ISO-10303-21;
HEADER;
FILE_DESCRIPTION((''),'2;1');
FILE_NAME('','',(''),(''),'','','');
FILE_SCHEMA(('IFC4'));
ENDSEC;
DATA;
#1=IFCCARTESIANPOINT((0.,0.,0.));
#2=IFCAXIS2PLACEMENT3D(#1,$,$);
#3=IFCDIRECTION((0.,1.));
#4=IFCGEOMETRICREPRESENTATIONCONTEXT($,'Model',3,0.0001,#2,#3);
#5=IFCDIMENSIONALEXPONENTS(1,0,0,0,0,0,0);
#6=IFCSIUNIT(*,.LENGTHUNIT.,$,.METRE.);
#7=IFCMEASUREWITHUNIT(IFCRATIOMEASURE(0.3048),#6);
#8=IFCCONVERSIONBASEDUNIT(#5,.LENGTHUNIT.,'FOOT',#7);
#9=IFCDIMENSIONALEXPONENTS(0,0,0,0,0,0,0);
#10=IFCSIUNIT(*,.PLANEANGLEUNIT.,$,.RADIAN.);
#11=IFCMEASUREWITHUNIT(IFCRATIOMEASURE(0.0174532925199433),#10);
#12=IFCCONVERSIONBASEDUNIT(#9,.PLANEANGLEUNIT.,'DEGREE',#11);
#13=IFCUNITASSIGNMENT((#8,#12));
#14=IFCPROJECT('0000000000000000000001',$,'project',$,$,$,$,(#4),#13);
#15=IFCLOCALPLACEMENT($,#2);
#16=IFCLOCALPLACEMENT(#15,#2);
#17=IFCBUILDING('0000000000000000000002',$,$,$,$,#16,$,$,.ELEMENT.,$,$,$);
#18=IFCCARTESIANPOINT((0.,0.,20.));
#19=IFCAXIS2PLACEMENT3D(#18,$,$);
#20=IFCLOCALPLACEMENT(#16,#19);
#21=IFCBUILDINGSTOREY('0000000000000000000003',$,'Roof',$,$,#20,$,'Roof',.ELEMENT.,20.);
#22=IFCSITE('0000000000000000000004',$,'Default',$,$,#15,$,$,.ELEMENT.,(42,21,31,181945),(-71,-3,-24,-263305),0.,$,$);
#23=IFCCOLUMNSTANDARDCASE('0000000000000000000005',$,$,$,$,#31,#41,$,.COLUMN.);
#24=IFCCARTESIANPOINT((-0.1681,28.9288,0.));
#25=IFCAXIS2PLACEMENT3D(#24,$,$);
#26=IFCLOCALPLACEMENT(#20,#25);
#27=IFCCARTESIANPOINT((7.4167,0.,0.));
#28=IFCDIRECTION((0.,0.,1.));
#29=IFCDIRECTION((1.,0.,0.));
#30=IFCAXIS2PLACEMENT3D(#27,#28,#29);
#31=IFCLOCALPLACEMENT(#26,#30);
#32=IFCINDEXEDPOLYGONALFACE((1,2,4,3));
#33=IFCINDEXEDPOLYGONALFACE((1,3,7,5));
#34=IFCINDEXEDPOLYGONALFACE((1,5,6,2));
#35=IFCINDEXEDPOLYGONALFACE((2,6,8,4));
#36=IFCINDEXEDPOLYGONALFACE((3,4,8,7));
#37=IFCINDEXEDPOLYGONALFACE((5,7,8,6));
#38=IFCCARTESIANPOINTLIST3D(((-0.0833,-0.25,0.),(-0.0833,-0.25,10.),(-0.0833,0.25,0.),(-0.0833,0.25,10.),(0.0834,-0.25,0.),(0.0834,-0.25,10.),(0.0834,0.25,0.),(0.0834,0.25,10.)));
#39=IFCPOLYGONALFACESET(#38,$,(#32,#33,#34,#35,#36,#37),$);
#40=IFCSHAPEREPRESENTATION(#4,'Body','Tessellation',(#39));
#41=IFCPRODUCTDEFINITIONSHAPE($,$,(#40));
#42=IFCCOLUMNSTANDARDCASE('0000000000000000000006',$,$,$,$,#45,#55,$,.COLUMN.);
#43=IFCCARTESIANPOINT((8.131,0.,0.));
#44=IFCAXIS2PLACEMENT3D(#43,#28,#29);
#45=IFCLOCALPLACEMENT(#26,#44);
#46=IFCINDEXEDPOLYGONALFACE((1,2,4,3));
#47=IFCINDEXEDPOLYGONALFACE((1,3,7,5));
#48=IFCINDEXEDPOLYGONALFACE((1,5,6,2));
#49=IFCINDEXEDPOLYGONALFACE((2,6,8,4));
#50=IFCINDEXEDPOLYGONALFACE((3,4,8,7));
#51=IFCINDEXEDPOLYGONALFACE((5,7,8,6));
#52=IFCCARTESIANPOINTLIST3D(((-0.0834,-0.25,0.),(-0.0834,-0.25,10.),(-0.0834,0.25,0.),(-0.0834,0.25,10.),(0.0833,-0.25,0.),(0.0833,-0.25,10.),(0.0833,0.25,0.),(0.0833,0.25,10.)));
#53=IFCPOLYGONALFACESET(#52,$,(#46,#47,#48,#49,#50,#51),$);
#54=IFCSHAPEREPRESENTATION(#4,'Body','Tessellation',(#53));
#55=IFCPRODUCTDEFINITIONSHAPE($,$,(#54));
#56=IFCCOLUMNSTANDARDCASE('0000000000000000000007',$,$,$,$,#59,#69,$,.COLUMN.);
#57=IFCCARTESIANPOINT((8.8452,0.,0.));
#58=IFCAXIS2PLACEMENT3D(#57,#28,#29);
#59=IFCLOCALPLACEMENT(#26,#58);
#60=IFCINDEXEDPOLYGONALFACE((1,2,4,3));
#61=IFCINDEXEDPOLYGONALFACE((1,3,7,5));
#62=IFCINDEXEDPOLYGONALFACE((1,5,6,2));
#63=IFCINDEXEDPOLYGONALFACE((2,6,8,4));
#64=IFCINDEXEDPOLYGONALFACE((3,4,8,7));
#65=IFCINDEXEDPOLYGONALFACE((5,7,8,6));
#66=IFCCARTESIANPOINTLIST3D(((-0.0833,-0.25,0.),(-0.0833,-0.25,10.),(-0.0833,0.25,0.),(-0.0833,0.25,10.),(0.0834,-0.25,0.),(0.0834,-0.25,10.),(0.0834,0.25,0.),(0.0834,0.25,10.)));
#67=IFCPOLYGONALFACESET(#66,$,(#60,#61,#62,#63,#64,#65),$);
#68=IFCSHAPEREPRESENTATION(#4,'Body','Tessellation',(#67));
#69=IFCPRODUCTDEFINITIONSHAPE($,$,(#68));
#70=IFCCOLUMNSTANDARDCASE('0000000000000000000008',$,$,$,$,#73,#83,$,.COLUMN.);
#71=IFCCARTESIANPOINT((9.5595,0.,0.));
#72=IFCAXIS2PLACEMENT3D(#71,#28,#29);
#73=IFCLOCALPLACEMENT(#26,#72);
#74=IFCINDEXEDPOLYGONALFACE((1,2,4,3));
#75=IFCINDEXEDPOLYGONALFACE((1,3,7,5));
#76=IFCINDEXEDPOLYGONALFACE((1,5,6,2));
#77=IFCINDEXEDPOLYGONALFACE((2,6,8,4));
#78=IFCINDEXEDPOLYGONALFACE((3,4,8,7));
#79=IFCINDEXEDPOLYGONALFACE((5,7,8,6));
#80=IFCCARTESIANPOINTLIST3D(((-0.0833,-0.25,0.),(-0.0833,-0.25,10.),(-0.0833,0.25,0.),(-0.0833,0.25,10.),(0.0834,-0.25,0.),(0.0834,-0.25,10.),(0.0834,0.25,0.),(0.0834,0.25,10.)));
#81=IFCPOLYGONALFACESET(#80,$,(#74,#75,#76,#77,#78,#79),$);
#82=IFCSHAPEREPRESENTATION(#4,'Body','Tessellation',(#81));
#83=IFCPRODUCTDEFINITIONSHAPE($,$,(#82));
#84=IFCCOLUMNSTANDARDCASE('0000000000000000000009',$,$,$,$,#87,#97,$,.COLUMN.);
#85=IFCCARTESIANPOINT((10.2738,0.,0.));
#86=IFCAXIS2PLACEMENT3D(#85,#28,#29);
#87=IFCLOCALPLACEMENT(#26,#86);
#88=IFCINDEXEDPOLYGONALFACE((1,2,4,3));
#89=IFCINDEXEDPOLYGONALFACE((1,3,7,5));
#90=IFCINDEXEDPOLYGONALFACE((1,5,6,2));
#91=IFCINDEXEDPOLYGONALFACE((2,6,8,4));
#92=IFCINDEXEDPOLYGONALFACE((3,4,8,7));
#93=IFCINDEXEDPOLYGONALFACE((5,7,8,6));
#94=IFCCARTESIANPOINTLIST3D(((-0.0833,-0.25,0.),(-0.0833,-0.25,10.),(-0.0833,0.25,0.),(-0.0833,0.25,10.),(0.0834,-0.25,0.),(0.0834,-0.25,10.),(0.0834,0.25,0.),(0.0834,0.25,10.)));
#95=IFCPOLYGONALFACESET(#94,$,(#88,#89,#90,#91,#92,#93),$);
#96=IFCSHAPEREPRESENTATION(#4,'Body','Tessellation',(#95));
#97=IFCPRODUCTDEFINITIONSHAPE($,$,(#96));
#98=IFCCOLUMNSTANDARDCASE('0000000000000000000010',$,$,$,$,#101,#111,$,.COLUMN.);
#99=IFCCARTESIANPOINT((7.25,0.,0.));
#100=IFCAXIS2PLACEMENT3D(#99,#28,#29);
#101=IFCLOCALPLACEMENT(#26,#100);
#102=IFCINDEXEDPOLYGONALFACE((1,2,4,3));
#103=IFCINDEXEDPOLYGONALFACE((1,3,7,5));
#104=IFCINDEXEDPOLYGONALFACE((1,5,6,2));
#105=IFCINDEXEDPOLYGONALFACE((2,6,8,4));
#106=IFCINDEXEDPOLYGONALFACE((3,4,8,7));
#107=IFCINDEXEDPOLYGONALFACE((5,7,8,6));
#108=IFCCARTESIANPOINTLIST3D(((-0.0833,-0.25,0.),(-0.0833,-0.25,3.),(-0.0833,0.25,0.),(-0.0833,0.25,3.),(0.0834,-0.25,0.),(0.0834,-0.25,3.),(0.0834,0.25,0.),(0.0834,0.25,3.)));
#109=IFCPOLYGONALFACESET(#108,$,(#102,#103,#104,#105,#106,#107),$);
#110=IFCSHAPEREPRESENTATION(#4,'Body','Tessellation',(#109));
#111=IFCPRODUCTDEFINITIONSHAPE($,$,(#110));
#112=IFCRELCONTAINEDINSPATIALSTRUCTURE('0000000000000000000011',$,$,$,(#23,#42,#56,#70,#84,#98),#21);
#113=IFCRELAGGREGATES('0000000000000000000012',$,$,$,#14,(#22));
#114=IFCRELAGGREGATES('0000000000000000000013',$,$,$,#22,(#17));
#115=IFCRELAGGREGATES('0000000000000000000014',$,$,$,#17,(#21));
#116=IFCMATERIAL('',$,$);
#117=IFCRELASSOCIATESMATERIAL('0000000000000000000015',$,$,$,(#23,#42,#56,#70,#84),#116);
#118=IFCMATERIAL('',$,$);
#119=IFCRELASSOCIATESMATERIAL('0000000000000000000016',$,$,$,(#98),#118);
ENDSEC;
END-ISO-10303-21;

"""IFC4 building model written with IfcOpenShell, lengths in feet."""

from ifc_helpers import new_model, entity, si_unit, converted_unit, direction, frame, origin, place, context, project, spatial, rectangle, extrude, material, element, save


model = new_model("IFC4")

# Units and contexts
model_context = context("Model", 3, precision=0.0001, world=origin(), true_north=direction((0.0, 1.0)))
ifc_project = project(units=[converted_unit("LENGTHUNIT", "FOOT", entity("IfcRatioMeasure", 0.3048), si_unit("LENGTHUNIT", "METRE"), dimensions=[1, 0, 0, 0, 0, 0, 0]), converted_unit("PLANEANGLEUNIT", "DEGREE", entity("IfcRatioMeasure", 0.0174532925199433), si_unit("PLANEANGLEUNIT", "RADIAN"), dimensions=[0, 0, 0, 0, 0, 0, 0])], contexts=[model_context])

# Site, building, storey
site_placement = place(None, origin())
site = spatial("IfcSite", under=ifc_project, at=site_placement, Name="Default", CompositionType="ELEMENT", RefLatitude=(42, 21, 31, 181945), RefLongitude=(-71, -3, -24, -263305), RefElevation=0.0)
building_placement = place(site_placement, origin())
building = spatial("IfcBuilding", under=site, at=building_placement, CompositionType="ELEMENT")
storey_placement = place(building_placement, frame((0.0, 0.0, 20.0)))
storey = spatial("IfcBuildingStorey", under=building, at=storey_placement, Name="Roof", LongName="Roof", CompositionType="ELEMENT", Elevation=20.0)

# Columns
ifc_material_1 = material(Name="")
placement = place(storey_placement, frame((-0.1681, 28.9288, 0.0)))
for number, where, z_axis, x_axis in (
    (1, (7.4167, 0.0, 0.0), (0.0, 0.0, 1.0), (1.0, 0.0, 0.0)),
    (2, (8.131, 0.0, 0.0), (0.0, 0.0, 1.0), (1.0, 0.0, 0.0)),
    (3, (8.8452, 0.0, 0.0), (0.0, 0.0, 1.0), (1.0, 0.0, 0.0)),
    (4, (9.5595, 0.0, 0.0), (0.0, 0.0, 1.0), (1.0, 0.0, 0.0)),
    (5, (10.2738, 0.0, 0.0), (0.0, 0.0, 1.0), (1.0, 0.0, 0.0)),
):
    element("IfcColumnStandardCase", number, at=place(placement, frame(where, z_axis=z_axis, x_axis=x_axis)), inside=storey, material=ifc_material_1, PredefinedType="COLUMN", context=model_context, shape_type="SweptSolid", body=[
        extrude(rectangle(XDim=0.1667, YDim=0.5), origin(), (0.0, 0.0, 1.0), 10.0),
    ])
ifc_material_2 = material(Name="")
for number, where, z_axis, x_axis in (
    (6, (7.25, 0.0, 0.0), (0.0, 0.0, 1.0), (1.0, 0.0, 0.0)),
):
    element("IfcColumnStandardCase", number, at=place(placement, frame(where, z_axis=z_axis, x_axis=x_axis)), inside=storey, material=ifc_material_2, PredefinedType="COLUMN", context=model_context, shape_type="SweptSolid", body=[
        extrude(rectangle(XDim=0.1667, YDim=0.5), origin(), (0.0, 0.0, 1.0), 3.0),
    ])

save(model, "model.ifc")
